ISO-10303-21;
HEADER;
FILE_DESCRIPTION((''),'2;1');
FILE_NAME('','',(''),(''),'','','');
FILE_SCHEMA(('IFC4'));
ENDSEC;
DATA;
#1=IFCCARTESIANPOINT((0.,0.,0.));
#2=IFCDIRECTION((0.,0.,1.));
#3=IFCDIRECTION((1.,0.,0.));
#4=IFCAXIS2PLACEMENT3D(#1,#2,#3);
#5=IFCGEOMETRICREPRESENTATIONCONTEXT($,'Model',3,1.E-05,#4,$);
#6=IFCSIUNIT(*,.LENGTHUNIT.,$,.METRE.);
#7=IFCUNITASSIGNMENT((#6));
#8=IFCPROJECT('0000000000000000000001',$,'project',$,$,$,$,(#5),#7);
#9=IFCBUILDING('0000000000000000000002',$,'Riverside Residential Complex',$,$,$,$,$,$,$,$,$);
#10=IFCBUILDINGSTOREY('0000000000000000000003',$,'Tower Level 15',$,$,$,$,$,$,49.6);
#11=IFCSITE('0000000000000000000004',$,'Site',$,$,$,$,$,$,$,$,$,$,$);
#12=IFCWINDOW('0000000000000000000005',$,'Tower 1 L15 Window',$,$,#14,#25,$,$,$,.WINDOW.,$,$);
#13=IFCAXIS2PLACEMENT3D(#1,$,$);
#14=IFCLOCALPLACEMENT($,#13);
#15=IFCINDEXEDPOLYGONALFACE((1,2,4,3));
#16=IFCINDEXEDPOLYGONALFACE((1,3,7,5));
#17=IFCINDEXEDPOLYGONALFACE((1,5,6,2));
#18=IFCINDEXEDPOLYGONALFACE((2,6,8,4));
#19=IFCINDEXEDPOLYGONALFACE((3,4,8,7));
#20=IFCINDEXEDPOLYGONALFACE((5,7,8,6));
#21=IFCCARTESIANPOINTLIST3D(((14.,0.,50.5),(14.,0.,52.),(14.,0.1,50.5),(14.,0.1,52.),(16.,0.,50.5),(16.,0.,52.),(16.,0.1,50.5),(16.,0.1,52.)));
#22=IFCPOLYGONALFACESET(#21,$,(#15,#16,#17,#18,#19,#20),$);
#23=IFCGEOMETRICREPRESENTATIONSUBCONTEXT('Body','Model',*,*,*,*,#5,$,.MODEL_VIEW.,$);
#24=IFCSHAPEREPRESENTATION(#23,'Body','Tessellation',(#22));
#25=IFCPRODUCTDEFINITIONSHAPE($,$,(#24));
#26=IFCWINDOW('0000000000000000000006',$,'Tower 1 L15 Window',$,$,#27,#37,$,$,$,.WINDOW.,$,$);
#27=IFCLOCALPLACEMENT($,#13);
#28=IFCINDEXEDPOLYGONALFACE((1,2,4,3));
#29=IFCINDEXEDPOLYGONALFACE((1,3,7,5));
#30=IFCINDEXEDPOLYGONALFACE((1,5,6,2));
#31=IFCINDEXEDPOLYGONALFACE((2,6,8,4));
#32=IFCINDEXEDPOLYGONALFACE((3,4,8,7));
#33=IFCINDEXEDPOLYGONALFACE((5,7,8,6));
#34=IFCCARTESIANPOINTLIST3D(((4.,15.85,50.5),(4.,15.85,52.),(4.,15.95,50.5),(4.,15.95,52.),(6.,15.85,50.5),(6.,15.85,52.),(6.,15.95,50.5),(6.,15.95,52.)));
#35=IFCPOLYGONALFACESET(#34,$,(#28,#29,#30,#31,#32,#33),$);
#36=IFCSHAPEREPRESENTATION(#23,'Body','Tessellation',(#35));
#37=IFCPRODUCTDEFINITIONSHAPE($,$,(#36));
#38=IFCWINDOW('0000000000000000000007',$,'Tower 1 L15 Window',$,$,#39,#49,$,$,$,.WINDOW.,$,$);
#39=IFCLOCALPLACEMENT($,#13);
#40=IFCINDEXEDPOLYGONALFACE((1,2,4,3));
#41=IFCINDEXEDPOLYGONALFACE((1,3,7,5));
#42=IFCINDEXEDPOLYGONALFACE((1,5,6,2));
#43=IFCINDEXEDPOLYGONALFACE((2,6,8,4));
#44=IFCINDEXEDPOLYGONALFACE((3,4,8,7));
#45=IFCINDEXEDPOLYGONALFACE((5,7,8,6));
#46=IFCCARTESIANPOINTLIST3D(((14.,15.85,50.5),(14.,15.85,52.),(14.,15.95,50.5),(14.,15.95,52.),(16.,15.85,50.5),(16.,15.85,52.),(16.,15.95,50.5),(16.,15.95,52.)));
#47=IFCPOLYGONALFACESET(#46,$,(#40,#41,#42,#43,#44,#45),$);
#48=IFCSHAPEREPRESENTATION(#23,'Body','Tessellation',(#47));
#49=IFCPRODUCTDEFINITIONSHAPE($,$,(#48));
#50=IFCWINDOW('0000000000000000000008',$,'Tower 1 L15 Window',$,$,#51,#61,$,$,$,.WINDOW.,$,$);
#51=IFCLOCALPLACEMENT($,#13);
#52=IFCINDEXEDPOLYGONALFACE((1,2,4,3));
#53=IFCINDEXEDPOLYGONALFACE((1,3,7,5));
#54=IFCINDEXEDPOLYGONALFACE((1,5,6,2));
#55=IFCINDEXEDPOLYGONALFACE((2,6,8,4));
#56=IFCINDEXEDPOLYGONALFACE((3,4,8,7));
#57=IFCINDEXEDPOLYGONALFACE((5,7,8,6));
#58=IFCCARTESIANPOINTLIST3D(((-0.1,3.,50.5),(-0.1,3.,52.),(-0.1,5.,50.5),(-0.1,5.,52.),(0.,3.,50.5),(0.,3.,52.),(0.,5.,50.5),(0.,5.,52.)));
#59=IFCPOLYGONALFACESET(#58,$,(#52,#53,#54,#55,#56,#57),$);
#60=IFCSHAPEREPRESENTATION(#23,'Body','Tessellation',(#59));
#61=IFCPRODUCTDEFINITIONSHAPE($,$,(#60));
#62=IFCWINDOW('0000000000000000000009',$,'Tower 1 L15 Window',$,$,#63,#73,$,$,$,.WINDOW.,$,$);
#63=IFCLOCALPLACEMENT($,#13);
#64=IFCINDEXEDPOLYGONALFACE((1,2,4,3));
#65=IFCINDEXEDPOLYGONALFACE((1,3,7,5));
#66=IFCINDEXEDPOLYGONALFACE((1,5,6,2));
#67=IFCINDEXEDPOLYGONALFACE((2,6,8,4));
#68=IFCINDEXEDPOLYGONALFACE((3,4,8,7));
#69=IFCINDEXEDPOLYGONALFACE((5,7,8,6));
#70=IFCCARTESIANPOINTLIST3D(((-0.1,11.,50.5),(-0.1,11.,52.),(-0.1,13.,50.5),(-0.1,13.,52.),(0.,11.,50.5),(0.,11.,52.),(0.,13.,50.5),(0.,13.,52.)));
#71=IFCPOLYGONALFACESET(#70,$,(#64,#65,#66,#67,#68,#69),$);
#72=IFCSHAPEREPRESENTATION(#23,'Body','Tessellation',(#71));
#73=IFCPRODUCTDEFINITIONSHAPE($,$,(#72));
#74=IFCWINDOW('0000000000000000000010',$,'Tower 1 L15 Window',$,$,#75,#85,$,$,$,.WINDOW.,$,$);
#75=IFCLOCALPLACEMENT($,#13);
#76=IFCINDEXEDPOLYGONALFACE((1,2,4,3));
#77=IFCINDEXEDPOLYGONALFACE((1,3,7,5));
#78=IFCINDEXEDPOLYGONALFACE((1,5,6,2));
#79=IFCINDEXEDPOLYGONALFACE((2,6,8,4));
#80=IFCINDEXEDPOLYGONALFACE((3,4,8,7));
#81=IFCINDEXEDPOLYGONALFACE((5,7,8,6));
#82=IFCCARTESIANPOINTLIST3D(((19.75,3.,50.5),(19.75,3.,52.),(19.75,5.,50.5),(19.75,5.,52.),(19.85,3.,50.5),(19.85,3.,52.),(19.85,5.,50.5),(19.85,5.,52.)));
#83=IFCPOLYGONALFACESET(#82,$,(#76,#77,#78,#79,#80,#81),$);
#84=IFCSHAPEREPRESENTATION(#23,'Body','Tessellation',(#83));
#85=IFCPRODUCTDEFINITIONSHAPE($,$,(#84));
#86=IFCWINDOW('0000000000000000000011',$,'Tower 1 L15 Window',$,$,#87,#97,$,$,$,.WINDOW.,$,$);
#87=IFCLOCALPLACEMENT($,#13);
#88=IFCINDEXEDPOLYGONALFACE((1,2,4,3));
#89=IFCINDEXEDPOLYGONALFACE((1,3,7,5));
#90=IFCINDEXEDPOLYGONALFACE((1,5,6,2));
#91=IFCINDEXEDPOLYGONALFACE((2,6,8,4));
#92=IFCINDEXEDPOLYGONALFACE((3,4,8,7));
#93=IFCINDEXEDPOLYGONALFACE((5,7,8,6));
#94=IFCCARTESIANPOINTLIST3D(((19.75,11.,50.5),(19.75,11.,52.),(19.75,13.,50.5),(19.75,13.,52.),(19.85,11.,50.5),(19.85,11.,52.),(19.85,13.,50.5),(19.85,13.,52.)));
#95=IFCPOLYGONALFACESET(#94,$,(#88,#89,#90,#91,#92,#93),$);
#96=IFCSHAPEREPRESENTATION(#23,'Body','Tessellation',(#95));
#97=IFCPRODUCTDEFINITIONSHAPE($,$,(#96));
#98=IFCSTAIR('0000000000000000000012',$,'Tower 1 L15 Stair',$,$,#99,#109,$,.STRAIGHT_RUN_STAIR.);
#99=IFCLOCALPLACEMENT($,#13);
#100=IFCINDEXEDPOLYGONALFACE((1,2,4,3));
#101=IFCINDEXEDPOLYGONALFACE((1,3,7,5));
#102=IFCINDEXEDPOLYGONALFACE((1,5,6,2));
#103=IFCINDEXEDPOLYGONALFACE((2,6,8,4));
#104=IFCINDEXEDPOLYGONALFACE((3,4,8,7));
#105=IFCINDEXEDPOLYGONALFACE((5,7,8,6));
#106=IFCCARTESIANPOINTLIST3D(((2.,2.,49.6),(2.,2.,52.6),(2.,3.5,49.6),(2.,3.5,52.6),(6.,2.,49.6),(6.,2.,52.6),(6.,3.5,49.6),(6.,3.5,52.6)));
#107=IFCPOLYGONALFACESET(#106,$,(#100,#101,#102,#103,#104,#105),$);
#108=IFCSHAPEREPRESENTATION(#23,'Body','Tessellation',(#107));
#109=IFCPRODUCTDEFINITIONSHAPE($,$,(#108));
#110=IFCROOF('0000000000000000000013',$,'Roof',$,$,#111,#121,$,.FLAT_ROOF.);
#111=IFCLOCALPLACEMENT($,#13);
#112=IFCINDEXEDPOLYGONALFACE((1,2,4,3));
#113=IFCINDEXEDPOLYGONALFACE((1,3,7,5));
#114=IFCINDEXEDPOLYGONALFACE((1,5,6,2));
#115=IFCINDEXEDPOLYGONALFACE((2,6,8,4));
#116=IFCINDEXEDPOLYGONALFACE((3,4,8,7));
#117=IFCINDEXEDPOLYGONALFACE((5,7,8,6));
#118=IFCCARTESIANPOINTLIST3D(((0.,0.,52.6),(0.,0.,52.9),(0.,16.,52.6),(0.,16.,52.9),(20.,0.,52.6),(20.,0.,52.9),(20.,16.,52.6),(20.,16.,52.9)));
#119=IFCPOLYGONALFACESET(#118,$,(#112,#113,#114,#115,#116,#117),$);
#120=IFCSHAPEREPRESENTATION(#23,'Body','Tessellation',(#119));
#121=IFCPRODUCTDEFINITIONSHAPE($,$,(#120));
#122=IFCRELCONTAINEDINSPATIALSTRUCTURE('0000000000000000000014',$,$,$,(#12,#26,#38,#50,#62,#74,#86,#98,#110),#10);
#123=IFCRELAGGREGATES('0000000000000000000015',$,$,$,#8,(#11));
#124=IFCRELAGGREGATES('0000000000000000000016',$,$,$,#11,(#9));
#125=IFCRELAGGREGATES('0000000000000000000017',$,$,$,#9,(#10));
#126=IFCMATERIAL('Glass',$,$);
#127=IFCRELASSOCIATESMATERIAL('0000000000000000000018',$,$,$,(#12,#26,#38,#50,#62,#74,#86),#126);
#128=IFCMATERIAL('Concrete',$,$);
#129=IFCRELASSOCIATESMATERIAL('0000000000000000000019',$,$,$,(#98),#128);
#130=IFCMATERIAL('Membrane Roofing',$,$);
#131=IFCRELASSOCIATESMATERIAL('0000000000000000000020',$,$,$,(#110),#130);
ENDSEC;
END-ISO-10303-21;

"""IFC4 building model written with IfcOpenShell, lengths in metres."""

from ifc_helpers import new_model, si_unit, frame, origin_with_axes, place, context, subcontext, project, spatial, line, indexed_curve, outline, extrude, material, element, save


model = new_model("IFC4")

# Units and contexts
model_context = context("Model", 3, precision=1e-05, world=origin_with_axes())
body_context = subcontext(model_context, "Body", "Model", "MODEL_VIEW")
ifc_project = project(units=[si_unit("LENGTHUNIT", "METRE")], contexts=[model_context])

# Site, building, storey
site = spatial("IfcSite", under=ifc_project, Name="Site")
building = spatial("IfcBuilding", under=site, Name="Riverside Residential Complex")
storey = spatial("IfcBuildingStorey", under=building, Name="Tower Level 15", Elevation=49.6)

# Shared definitions
ifc_material_1 = material(Name="Concrete")

# Windows
ifc_material_2 = material(Name="Glass")
for number, where, z_axis, x_axis, name in (
    (1, (14.0, 0.0, 50.5), (0.0, 0.0, 1.0), (1.0, 0.0, 0.0), "Tower 1 L15 Window"),
    (2, (4.0, 15.85, 50.5), (0.0, 0.0, 1.0), (1.0, 0.0, 0.0), "Tower 1 L15 Window"),
    (3, (14.0, 15.85, 50.5), (0.0, 0.0, 1.0), (1.0, 0.0, 0.0), "Tower 1 L15 Window"),
    (4, (0.0, 3.0, 50.5), (0.0, 0.0, 1.0), (0.0, 1.0, 0.0), "Tower 1 L15 Window"),
    (5, (0.0, 11.0, 50.5), (0.0, 0.0, 1.0), (0.0, 1.0, 0.0), "Tower 1 L15 Window"),
    (6, (19.85, 3.0, 50.5), (0.0, 0.0, 1.0), (0.0, 1.0, 0.0), "Tower 1 L15 Window"),
    (7, (19.85, 11.0, 50.5), (0.0, 0.0, 1.0), (0.0, 1.0, 0.0), "Tower 1 L15 Window"),
):
    element("IfcWindow", number, at=place(None, frame(where, z_axis=z_axis, x_axis=x_axis)), inside=storey, material=ifc_material_2, Name=name, PredefinedType="WINDOW", context=body_context, shape_type="SweptSolid", body=[
        extrude(outline(indexed_curve([(0.0, 0.0), (2.0, 0.0), (2.0, 0.1), (0.0, 0.1)], segments=[line(1, 2, 3, 4, 1)])), origin_with_axes(), (0.0, 0.0, 1.0), 1.5),
    ])

# Stair
stair_placement = place(None, frame((2.0, 2.0, 49.6), z_axis=(0.0, 0.0, 1.0), x_axis=(1.0, 0.0, 0.0)))
element("IfcStair", 8, at=stair_placement, inside=storey, material=ifc_material_1, Name="Tower 1 L15 Stair", PredefinedType="STRAIGHT_RUN_STAIR", context=body_context, shape_type="SweptSolid", body=[
    extrude(outline(indexed_curve([(0.0, 0.0), (4.0, 0.0), (4.0, 1.5), (0.0, 1.5)], segments=[line(1, 2, 3, 4, 1)])), origin_with_axes(), (0.0, 0.0, 1.0), 3.0),
])

# Roof
ifc_material_3 = material(Name="Membrane Roofing")
roof_placement = place(None, frame((0.0, 0.0, 52.6), z_axis=(0.0, 0.0, 1.0), x_axis=(1.0, 0.0, 0.0)))
element("IfcRoof", 9, at=roof_placement, inside=storey, material=ifc_material_3, Name="Roof", PredefinedType="FLAT_ROOF", context=body_context, shape_type="SweptSolid", body=[
    extrude(outline(indexed_curve([(0.0, 0.0), (20.0, 0.0), (20.0, 16.0), (0.0, 16.0)], segments=[line(1, 2, 3, 4, 1)])), origin_with_axes(), (0.0, 0.0, 1.0), 0.3),
])

save(model, "model.ifc")
